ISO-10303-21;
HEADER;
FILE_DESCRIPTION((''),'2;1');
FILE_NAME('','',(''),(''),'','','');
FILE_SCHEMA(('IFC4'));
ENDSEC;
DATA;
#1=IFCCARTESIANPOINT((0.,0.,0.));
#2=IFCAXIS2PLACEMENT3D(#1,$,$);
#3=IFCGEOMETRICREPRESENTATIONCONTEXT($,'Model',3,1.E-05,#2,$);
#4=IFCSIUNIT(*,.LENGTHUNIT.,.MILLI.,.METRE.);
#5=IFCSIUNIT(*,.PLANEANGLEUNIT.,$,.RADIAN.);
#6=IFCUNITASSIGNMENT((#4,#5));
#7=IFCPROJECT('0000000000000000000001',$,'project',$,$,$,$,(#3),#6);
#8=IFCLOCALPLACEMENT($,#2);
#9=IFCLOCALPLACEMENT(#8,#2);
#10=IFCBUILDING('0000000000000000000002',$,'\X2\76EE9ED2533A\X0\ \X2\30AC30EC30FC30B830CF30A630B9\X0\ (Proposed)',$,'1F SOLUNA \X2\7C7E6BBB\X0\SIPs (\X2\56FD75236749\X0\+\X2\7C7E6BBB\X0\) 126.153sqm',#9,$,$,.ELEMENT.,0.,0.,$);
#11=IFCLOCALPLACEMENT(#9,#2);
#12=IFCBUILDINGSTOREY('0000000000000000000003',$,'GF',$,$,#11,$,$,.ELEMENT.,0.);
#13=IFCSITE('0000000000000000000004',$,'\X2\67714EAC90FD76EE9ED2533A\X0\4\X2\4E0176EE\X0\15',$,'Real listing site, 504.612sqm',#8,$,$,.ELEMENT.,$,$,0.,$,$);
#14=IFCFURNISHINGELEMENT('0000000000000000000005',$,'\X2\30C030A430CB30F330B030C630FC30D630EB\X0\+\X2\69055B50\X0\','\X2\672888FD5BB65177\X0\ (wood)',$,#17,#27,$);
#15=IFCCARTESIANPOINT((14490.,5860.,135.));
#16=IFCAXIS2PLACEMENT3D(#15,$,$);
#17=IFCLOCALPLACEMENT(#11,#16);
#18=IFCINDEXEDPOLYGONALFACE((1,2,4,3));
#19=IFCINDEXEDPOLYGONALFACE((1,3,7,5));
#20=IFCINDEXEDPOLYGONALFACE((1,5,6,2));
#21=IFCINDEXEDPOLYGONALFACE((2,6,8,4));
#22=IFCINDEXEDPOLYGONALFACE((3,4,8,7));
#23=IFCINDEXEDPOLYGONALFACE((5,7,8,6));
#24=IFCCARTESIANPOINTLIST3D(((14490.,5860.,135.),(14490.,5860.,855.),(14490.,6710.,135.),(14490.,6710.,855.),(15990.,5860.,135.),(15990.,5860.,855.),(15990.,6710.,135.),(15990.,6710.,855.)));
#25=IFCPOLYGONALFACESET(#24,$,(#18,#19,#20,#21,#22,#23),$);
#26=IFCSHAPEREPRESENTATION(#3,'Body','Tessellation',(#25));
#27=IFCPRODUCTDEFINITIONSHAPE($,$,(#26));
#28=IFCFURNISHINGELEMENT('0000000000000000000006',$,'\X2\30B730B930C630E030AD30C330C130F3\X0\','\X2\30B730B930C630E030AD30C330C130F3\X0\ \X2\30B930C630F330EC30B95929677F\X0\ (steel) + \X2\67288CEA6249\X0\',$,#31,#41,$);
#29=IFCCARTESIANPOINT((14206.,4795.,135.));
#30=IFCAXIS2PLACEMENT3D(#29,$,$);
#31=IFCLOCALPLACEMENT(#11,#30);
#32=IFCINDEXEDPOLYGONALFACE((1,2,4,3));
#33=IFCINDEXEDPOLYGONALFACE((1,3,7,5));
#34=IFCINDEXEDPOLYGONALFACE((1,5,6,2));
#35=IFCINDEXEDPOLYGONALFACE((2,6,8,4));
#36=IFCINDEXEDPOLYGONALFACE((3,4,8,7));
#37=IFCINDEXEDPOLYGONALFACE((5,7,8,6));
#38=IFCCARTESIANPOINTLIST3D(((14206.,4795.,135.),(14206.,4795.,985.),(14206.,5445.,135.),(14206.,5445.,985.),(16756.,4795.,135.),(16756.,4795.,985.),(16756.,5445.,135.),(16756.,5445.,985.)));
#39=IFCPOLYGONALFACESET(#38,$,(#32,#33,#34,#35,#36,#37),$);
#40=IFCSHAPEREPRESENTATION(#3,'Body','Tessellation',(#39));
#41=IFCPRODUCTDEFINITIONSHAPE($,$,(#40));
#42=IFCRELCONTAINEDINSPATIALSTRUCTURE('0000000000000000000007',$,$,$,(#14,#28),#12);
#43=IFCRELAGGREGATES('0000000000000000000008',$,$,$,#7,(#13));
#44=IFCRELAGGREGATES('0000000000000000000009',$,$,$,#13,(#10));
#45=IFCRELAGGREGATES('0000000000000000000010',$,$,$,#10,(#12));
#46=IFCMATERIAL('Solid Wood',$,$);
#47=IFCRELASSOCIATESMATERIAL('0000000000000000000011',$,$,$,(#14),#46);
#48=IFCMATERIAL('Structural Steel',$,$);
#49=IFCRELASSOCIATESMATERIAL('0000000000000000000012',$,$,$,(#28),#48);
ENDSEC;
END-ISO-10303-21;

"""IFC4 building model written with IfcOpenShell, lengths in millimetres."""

from ifc_helpers import new_model, si_unit, frame, frame_2d, origin, place, context, project, spatial, rectangle, extrude, material, element, save


model = new_model("IFC4")

# Units and contexts
model_context = context("Model", 3, precision=1e-05, world=origin())
ifc_project = project(units=[si_unit("LENGTHUNIT", "METRE", prefix="MILLI"), si_unit("PLANEANGLEUNIT", "RADIAN")], contexts=[model_context])

# Site, building, storey
site_placement = place(None, origin())
site = spatial("IfcSite", under=ifc_project, at=site_placement, Name="東京都目黒区4丁目15", ObjectType="Real listing site, 504.612sqm", CompositionType="ELEMENT", RefElevation=0.0)
building_placement = place(site_placement, origin())
building = spatial("IfcBuilding", under=site, at=building_placement, Name="目黒区 ガレージハウス (Proposed)", ObjectType="1F SOLUNA 籾殻SIPs (国産杉+籾殻) 126.153sqm", CompositionType="ELEMENT", ElevationOfRefHeight=0.0, ElevationOfTerrain=0.0)
storey_placement = place(building_placement, origin())
storey = spatial("IfcBuildingStorey", under=building, at=storey_placement, Name="GF", CompositionType="ELEMENT", Elevation=0.0)

# Shared definitions
ifc_material_1 = material(Name="Solid Wood")

# Shared definitions
ifc_material_2 = material(Name="Structural Steel")

# Furnishing elements
furnishing_1_placement = place(storey_placement, frame((14490.0, 5860.0, 135.0)))
element("IfcFurnishingElement", 1, at=furnishing_1_placement, inside=storey, material=ifc_material_1, Name="ダイニングテーブル+椅子", Description="木製家具 (wood)", context=model_context, shape_type="SweptSolid", body=[
    extrude(rectangle(XDim=1500.0, YDim=850.0, at=frame_2d((750.0, 425.0))), frame((14490.0, 5860.0, 135.0)), (0.0, 0.0, 1.0), 720.0),
])
furnishing_2_placement = place(storey_placement, frame((14206.0, 4795.0, 135.0)))
element("IfcFurnishingElement", 2, at=furnishing_2_placement, inside=storey, material=ifc_material_2, Name="システムキッチン", Description="システムキッチン ステンレス天板 (steel) + 木質扉", context=model_context, shape_type="SweptSolid", body=[
    extrude(rectangle(XDim=2550.0, YDim=650.0, at=frame_2d((1275.0, 325.0))), frame((14206.0, 4795.0, 135.0)), (0.0, 0.0, 1.0), 850.0),
])

save(model, "model.ifc")
